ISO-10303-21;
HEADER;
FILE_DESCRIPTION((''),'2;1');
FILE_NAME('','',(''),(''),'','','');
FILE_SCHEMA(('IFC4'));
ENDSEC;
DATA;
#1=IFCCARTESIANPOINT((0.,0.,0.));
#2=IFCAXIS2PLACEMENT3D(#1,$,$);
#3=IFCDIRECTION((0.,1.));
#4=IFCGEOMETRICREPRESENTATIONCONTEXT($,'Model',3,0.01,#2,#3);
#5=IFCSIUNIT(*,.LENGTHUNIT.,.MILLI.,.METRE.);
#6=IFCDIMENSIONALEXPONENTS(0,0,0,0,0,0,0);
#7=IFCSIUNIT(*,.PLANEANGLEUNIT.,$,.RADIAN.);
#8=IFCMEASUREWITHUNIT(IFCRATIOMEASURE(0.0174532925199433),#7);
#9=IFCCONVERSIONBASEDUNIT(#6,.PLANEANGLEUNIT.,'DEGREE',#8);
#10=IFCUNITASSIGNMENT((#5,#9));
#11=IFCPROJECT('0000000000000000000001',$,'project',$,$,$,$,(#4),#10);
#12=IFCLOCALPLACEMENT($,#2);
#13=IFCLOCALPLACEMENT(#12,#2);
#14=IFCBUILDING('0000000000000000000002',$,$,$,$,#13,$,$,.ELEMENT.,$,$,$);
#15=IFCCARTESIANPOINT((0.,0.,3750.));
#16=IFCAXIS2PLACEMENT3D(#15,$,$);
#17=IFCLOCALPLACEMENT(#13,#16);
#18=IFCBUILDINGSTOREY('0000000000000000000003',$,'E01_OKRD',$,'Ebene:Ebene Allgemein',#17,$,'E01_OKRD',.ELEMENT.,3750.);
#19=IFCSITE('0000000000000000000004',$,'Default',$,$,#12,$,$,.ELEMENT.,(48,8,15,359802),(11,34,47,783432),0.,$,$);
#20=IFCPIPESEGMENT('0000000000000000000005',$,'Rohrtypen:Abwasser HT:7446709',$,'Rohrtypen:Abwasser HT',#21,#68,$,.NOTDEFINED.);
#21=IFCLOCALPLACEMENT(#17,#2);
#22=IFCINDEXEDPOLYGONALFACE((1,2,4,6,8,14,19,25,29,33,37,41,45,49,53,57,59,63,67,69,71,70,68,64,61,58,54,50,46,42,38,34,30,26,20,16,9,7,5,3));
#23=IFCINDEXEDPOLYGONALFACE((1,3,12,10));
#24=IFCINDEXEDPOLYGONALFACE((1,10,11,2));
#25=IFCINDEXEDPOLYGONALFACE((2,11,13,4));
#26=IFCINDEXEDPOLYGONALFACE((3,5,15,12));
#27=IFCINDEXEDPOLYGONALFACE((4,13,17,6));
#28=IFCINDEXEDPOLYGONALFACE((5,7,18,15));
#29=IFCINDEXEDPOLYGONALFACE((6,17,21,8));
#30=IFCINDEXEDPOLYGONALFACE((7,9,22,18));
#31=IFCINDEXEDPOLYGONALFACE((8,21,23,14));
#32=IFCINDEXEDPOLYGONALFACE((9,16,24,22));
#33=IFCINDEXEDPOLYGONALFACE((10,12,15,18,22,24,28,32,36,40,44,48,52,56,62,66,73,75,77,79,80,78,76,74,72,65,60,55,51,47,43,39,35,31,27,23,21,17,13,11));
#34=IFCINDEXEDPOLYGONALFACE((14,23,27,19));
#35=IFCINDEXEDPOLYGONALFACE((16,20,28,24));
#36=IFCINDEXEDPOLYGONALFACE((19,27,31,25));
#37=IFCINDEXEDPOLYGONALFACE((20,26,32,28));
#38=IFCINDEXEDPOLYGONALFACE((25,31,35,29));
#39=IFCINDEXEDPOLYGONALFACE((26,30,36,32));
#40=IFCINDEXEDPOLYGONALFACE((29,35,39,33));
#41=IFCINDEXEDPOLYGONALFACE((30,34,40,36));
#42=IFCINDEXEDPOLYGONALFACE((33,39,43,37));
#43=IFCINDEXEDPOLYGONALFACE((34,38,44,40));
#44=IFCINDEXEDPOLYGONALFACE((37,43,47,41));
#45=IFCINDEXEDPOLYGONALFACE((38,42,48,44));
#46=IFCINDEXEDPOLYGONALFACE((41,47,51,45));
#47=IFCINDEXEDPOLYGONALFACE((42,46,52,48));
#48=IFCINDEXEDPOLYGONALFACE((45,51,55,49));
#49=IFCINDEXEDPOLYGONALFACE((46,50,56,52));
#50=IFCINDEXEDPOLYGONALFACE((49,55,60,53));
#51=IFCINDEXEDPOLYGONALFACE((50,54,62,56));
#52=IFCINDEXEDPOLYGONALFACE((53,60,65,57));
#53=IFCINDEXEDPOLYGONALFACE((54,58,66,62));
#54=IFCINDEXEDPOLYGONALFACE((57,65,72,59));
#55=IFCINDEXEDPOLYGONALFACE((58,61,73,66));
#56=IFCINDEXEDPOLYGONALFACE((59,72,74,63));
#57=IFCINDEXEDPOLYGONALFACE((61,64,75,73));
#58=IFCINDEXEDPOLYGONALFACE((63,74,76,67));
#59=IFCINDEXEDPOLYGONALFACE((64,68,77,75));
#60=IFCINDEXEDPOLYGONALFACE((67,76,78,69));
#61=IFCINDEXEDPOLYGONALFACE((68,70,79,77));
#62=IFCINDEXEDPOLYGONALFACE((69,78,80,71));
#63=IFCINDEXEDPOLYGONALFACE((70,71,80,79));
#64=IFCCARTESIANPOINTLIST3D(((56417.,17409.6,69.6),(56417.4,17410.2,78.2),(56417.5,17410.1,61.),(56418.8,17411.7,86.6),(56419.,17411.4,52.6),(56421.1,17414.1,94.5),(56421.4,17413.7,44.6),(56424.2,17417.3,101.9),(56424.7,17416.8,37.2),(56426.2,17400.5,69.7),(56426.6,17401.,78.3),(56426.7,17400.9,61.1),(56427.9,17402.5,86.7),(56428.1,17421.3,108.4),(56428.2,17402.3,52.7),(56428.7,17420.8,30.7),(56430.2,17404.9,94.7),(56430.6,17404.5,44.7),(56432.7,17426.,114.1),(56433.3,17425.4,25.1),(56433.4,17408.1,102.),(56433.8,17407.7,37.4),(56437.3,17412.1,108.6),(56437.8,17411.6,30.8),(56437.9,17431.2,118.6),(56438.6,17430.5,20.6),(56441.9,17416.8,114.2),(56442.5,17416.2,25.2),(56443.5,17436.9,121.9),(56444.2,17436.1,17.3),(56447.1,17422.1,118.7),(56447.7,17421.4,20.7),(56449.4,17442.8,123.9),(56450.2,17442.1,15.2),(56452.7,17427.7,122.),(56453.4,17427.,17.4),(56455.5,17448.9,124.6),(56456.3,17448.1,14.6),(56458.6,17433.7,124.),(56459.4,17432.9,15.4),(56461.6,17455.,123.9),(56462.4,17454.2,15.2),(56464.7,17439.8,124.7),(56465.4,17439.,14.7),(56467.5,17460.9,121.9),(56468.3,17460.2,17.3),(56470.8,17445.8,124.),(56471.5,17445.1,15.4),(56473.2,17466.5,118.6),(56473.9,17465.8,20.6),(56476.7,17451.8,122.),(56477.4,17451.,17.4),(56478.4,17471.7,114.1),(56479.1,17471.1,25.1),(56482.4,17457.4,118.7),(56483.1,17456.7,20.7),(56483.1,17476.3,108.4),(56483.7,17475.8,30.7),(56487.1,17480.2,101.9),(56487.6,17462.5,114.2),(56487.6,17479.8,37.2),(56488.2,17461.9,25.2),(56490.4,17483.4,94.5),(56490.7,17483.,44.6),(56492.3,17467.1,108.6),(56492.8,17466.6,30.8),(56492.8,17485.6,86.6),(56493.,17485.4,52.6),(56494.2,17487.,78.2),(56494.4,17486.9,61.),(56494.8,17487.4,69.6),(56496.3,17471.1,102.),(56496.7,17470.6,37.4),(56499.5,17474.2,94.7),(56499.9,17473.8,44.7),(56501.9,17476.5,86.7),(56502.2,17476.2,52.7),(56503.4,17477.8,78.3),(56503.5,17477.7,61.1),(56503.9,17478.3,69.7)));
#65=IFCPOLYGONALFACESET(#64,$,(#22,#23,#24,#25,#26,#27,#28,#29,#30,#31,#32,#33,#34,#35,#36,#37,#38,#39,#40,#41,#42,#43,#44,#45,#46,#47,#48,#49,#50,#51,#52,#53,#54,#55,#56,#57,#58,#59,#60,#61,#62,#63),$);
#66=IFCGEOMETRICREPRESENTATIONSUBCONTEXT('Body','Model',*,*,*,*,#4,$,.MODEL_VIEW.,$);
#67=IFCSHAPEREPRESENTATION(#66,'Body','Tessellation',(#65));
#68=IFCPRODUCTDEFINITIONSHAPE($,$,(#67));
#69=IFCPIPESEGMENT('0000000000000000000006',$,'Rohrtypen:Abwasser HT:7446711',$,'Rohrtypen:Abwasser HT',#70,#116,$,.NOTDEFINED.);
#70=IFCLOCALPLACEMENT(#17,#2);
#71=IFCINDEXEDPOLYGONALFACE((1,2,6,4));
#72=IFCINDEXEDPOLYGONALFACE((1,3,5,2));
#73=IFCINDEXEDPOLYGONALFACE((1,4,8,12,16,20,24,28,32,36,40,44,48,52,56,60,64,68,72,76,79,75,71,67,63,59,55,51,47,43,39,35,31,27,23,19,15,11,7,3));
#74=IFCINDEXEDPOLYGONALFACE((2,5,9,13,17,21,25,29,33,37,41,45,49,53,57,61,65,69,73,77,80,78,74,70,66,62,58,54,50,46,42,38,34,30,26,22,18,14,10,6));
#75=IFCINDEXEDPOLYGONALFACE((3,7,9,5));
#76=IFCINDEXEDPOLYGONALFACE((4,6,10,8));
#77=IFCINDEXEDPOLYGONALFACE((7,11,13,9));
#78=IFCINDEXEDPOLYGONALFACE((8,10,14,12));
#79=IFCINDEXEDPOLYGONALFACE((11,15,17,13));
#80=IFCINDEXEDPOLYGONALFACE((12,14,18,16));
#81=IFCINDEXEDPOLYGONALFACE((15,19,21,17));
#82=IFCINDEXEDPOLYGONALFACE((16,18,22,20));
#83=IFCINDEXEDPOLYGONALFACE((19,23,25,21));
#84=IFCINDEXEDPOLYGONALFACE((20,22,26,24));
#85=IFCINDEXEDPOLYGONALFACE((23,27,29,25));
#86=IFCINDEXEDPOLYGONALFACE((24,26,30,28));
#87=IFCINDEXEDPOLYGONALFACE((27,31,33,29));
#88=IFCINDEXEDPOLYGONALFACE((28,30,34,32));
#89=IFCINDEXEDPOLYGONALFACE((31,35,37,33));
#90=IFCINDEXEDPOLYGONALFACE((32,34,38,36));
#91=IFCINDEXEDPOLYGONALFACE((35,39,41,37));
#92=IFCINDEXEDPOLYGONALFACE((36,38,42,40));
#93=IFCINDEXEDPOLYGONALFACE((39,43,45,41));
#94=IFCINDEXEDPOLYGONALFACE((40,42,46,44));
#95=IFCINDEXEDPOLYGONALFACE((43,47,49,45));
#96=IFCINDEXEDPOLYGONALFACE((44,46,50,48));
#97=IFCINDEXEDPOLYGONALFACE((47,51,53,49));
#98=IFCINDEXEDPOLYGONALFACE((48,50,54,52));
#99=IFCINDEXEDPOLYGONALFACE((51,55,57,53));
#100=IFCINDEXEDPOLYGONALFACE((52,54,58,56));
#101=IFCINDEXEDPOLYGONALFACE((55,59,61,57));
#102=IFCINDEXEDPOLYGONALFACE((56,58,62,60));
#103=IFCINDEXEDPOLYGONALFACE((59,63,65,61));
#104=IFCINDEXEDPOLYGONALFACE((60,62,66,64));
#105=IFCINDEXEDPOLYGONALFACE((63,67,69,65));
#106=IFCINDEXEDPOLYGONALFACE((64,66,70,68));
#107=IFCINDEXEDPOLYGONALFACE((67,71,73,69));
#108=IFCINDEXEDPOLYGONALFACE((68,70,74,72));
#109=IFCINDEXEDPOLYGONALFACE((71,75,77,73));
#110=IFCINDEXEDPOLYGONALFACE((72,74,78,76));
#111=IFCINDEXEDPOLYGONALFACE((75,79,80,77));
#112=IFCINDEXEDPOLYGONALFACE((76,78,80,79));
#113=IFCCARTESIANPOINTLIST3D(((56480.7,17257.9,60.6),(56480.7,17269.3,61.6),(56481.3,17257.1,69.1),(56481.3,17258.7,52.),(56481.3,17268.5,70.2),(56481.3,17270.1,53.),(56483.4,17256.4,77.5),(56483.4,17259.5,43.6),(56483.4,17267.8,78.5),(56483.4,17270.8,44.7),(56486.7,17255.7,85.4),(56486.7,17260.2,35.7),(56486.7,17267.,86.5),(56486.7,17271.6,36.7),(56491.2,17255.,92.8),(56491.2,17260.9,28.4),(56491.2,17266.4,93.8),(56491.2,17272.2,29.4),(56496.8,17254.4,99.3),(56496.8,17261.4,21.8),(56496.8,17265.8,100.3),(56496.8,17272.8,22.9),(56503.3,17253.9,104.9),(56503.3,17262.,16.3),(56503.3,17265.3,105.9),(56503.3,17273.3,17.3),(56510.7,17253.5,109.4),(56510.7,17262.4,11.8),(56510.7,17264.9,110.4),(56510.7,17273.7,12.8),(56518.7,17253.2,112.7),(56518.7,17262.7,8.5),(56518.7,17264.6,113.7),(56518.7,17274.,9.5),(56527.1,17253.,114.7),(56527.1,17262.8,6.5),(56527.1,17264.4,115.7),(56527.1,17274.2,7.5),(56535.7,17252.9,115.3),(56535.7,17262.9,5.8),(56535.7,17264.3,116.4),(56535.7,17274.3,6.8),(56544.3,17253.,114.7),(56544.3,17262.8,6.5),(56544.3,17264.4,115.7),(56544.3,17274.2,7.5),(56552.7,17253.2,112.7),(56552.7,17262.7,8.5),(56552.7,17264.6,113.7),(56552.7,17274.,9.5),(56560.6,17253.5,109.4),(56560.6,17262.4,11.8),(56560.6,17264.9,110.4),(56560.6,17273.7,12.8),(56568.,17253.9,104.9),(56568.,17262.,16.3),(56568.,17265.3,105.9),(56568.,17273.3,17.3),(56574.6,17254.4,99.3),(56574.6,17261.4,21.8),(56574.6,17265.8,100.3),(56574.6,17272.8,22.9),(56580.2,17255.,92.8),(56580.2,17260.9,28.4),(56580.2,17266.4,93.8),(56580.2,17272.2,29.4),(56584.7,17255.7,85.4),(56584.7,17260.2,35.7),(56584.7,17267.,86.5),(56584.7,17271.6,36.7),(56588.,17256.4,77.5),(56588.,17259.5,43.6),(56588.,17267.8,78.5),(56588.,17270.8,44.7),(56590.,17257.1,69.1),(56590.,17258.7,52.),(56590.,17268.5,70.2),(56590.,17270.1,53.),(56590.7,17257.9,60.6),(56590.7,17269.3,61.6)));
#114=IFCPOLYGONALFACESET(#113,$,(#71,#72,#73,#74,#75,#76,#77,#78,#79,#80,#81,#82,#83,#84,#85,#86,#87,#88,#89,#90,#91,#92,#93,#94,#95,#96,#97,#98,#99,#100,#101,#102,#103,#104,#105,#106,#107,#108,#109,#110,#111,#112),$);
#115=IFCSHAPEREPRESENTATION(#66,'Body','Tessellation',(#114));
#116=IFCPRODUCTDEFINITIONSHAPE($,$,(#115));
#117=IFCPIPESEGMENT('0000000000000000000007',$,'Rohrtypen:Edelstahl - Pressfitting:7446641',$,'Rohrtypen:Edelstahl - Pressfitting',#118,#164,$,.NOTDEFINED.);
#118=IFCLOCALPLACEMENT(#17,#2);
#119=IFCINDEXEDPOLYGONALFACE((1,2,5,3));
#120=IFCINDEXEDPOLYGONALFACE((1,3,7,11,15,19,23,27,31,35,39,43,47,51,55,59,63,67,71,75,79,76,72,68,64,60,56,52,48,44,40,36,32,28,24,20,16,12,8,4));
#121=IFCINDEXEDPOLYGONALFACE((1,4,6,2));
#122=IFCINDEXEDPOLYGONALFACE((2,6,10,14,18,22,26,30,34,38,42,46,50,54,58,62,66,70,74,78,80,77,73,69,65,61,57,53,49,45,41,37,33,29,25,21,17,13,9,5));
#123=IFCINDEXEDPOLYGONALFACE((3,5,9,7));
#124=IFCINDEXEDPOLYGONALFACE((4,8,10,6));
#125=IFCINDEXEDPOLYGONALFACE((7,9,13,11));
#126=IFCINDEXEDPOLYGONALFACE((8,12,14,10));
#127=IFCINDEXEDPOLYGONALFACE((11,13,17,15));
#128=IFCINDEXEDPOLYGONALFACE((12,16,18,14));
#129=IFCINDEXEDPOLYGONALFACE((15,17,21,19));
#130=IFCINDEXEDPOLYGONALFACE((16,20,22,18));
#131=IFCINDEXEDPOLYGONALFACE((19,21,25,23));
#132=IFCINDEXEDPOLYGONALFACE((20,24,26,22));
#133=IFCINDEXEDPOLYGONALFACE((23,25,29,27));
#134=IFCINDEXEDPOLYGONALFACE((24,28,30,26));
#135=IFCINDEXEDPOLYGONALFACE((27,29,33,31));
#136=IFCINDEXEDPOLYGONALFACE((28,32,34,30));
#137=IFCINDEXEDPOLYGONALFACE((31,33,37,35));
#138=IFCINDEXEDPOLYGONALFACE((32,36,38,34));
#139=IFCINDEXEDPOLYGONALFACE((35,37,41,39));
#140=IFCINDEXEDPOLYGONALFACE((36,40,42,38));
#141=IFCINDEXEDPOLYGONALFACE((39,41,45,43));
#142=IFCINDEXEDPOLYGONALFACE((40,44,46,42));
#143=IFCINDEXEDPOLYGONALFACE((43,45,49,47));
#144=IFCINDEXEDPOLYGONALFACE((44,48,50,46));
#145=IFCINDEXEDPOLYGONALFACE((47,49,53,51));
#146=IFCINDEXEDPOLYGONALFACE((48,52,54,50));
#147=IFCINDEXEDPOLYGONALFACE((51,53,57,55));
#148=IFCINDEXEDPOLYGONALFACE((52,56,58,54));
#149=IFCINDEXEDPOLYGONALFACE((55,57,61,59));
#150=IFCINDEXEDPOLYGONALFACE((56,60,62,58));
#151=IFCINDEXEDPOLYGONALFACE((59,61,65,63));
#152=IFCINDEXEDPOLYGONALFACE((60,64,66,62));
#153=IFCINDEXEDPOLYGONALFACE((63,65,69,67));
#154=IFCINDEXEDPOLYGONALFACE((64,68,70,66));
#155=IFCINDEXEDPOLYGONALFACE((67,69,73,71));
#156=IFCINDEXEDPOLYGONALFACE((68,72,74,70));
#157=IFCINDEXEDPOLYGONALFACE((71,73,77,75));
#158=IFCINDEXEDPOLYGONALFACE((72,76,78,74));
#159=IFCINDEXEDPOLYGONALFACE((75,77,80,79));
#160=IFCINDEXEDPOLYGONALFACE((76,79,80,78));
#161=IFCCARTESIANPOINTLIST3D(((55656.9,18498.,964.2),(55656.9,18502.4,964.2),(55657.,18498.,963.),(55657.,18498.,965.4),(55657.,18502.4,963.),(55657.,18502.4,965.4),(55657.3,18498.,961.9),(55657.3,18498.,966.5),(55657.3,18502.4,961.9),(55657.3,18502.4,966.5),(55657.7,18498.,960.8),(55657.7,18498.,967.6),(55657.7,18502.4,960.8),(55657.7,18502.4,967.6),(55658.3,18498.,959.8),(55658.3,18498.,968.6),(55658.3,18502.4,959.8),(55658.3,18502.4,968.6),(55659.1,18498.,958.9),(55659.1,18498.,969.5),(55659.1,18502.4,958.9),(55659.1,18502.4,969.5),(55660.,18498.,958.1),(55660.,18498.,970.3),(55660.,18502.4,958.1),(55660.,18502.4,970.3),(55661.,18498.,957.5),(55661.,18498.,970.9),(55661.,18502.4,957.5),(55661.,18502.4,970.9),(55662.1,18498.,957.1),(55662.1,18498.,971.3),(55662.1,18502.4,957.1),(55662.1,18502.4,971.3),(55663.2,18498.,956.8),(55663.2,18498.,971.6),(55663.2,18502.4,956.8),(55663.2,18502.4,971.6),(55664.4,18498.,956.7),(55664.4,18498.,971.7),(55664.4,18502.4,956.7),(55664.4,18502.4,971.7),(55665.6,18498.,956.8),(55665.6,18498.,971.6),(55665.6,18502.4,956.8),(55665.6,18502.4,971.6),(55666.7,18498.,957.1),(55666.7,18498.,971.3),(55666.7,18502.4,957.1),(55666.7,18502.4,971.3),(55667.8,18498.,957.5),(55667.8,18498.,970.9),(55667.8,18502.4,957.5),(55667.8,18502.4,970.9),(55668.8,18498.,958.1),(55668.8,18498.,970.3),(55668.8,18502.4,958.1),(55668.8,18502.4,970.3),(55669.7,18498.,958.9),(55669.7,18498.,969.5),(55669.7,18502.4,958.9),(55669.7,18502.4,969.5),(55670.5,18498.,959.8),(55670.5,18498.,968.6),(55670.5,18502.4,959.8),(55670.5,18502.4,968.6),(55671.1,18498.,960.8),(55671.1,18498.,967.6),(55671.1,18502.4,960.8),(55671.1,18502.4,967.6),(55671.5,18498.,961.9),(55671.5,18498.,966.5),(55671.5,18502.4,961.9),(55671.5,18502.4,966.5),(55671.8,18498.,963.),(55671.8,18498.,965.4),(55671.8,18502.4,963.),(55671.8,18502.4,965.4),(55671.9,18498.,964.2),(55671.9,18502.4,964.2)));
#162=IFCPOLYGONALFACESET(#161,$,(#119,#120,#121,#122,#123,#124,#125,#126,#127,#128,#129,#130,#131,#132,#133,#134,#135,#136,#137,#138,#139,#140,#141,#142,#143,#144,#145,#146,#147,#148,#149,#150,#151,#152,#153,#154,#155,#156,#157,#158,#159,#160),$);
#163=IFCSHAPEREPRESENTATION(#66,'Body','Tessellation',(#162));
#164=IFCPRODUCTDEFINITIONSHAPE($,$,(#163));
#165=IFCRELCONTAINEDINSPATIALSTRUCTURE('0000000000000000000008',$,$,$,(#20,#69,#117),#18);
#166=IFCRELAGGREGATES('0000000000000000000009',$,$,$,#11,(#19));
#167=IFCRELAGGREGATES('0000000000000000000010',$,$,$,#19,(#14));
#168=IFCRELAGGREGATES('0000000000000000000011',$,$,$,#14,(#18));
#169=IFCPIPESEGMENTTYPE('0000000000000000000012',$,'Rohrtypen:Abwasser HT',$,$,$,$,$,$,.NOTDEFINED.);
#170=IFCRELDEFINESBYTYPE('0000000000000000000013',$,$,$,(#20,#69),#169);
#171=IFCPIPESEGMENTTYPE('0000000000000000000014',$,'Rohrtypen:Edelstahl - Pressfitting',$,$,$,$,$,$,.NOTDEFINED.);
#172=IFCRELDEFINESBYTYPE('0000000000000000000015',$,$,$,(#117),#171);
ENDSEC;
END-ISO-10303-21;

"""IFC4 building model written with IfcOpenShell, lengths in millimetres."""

from ifc_helpers import new_model, entity, si_unit, converted_unit, direction, frame, origin, place, context, subcontext, project, spatial, indexed_curve, outline, extrude, type_object, element, save


model = new_model("IFC4")

# Units and contexts
model_context = context("Model", 3, precision=0.01, world=origin(), true_north=direction((0.0, 1.0)))
body_context = subcontext(model_context, "Body", "Model", "MODEL_VIEW")
ifc_project = project(units=[si_unit("LENGTHUNIT", "METRE", prefix="MILLI"), converted_unit("PLANEANGLEUNIT", "DEGREE", entity("IfcRatioMeasure", 0.0174532925199433), si_unit("PLANEANGLEUNIT", "RADIAN"), dimensions=[0, 0, 0, 0, 0, 0, 0])], contexts=[model_context])

# Site, building, storey
site_placement = place(None, origin())
site = spatial("IfcSite", under=ifc_project, at=site_placement, Name="Default", CompositionType="ELEMENT", RefLatitude=(48, 8, 15, 359802), RefLongitude=(11, 34, 47, 783432), RefElevation=0.0)
building_placement = place(site_placement, origin())
building = spatial("IfcBuilding", under=site, at=building_placement, CompositionType="ELEMENT")
storey_placement = place(building_placement, frame((0.0, 0.0, 3750.0)))
storey = spatial("IfcBuildingStorey", under=building, at=storey_placement, Name="E01_OKRD", ObjectType="Ebene:Ebene Allgemein", LongName="E01_OKRD", CompositionType="ELEMENT", Elevation=3750.0)

# Pipe segments
pipe_segment_type_1 = type_object("IfcPipeSegmentType", Name="Rohrtypen:Abwasser HT", PredefinedType="NOTDEFINED")
pipe_segment_1_placement = place(storey_placement, origin())
element("IfcPipeSegment", 1, at=pipe_segment_1_placement, inside=storey, type_object=pipe_segment_type_1, Name="Rohrtypen:Abwasser HT:7446709", ObjectType="Rohrtypen:Abwasser HT", PredefinedType="NOTDEFINED", context=body_context, shape_type="SweptSolid", body=[
    extrude(outline(indexed_curve([(55.0, 0.0), (54.3, 8.6), (52.3, 17.0), (49.0, 25.0), (44.5, 32.3), (38.9, 38.9), (32.3, 44.5), (25.0, 49.0), (17.0, 52.3), (8.6, 54.3), (0.0, 55.0), (-8.6, 54.3), (-17.0, 52.3), (-25.0, 49.0), (-32.3, 44.5), (-38.9, 38.9), (-44.5, 32.3), (-49.0, 25.0), (-52.3, 17.0), (-54.3, 8.6), (-55.0, 0.0), (-54.3, -8.6), (-52.3, -17.0), (-49.0, -25.0), (-44.5, -32.3), (-38.9, -38.9), (-32.3, -44.5), (-25.0, -49.0), (-17.0, -52.3), (-8.6, -54.3), (0.0, -55.0), (8.6, -54.3), (17.0, -52.3), (25.0, -49.0), (32.3, -44.5), (38.9, -38.9), (44.5, -32.3), (49.0, -25.0), (52.3, -17.0), (54.3, -8.6), (55.0, 0.0)], self_intersect=False)), frame((56455.9, 17448.5, 69.6), z_axis=(0.707071, -0.707071, 0.01), x_axis=(-0.707107, -0.707107, 0.0)), (0.0, 0.0, 1.0), 13.0),
])
pipe_segment_2_placement = place(storey_placement, origin())
element("IfcPipeSegment", 2, at=pipe_segment_2_placement, inside=storey, type_object=pipe_segment_type_1, Name="Rohrtypen:Abwasser HT:7446711", ObjectType="Rohrtypen:Abwasser HT", PredefinedType="NOTDEFINED", context=body_context, shape_type="SweptSolid", body=[
    extrude(outline(indexed_curve([(55.0, 0.0), (54.3, 8.6), (52.3, 17.0), (49.0, 25.0), (44.5, 32.3), (38.9, 38.9), (32.3, 44.5), (25.0, 49.0), (17.0, 52.3), (8.6, 54.3), (0.0, 55.0), (-8.6, 54.3), (-17.0, 52.3), (-25.0, 49.0), (-32.3, 44.5), (-38.9, 38.9), (-44.5, 32.3), (-49.0, 25.0), (-52.3, 17.0), (-54.3, 8.6), (-55.0, 0.0), (-54.3, -8.6), (-52.3, -17.0), (-49.0, -25.0), (-44.5, -32.3), (-38.9, -38.9), (-32.3, -44.5), (-25.0, -49.0), (-17.0, -52.3), (-8.6, -54.3), (0.0, -55.0), (8.6, -54.3), (17.0, -52.3), (25.0, -49.0), (32.3, -44.5), (38.9, -38.9), (44.5, -32.3), (49.0, -25.0), (52.3, -17.0), (54.3, -8.6), (55.0, 0.0)], self_intersect=False)), frame((56535.7, 17257.9, 60.6), z_axis=(0.0, 0.995894, 0.090528), x_axis=(-1.0, 0.0, 0.0)), (0.0, 0.0, 1.0), 11.4),
])
pipe_segment_type_2 = type_object("IfcPipeSegmentType", Name="Rohrtypen:Edelstahl - Pressfitting", PredefinedType="NOTDEFINED")
pipe_segment_3_placement = place(storey_placement, origin())
element("IfcPipeSegment", 3, at=pipe_segment_3_placement, inside=storey, type_object=pipe_segment_type_2, Name="Rohrtypen:Edelstahl - Pressfitting:7446641", ObjectType="Rohrtypen:Edelstahl - Pressfitting", PredefinedType="NOTDEFINED", context=body_context, shape_type="SweptSolid", body=[
    extrude(outline(indexed_curve([(7.5, 0.0), (7.4, 1.2), (7.1, 2.3), (6.7, 3.4), (6.1, 4.4), (5.3, 5.3), (4.4, 6.1), (3.4, 6.7), (2.3, 7.1), (1.2, 7.4), (0.0, 7.5), (-1.2, 7.4), (-2.3, 7.1), (-3.4, 6.7), (-4.4, 6.1), (-5.3, 5.3), (-6.1, 4.4), (-6.7, 3.4), (-7.1, 2.3), (-7.4, 1.2), (-7.5, 0.0), (-7.4, -1.2), (-7.1, -2.3), (-6.7, -3.4), (-6.1, -4.4), (-5.3, -5.3), (-4.4, -6.1), (-3.4, -6.7), (-2.3, -7.1), (-1.2, -7.4), (0.0, -7.5), (1.2, -7.4), (2.3, -7.1), (3.4, -6.7), (4.4, -6.1), (5.3, -5.3), (6.1, -4.4), (6.7, -3.4), (7.1, -2.3), (7.4, -1.2), (7.5, 0.0)], self_intersect=False)), frame((55664.4, 18498.0, 964.2), z_axis=(0.0, 1.0, 0.0), x_axis=(1.0, 0.0, 0.0)), (0.0, 0.0, 1.0), 4.4),
])

save(model, "model.ifc")
